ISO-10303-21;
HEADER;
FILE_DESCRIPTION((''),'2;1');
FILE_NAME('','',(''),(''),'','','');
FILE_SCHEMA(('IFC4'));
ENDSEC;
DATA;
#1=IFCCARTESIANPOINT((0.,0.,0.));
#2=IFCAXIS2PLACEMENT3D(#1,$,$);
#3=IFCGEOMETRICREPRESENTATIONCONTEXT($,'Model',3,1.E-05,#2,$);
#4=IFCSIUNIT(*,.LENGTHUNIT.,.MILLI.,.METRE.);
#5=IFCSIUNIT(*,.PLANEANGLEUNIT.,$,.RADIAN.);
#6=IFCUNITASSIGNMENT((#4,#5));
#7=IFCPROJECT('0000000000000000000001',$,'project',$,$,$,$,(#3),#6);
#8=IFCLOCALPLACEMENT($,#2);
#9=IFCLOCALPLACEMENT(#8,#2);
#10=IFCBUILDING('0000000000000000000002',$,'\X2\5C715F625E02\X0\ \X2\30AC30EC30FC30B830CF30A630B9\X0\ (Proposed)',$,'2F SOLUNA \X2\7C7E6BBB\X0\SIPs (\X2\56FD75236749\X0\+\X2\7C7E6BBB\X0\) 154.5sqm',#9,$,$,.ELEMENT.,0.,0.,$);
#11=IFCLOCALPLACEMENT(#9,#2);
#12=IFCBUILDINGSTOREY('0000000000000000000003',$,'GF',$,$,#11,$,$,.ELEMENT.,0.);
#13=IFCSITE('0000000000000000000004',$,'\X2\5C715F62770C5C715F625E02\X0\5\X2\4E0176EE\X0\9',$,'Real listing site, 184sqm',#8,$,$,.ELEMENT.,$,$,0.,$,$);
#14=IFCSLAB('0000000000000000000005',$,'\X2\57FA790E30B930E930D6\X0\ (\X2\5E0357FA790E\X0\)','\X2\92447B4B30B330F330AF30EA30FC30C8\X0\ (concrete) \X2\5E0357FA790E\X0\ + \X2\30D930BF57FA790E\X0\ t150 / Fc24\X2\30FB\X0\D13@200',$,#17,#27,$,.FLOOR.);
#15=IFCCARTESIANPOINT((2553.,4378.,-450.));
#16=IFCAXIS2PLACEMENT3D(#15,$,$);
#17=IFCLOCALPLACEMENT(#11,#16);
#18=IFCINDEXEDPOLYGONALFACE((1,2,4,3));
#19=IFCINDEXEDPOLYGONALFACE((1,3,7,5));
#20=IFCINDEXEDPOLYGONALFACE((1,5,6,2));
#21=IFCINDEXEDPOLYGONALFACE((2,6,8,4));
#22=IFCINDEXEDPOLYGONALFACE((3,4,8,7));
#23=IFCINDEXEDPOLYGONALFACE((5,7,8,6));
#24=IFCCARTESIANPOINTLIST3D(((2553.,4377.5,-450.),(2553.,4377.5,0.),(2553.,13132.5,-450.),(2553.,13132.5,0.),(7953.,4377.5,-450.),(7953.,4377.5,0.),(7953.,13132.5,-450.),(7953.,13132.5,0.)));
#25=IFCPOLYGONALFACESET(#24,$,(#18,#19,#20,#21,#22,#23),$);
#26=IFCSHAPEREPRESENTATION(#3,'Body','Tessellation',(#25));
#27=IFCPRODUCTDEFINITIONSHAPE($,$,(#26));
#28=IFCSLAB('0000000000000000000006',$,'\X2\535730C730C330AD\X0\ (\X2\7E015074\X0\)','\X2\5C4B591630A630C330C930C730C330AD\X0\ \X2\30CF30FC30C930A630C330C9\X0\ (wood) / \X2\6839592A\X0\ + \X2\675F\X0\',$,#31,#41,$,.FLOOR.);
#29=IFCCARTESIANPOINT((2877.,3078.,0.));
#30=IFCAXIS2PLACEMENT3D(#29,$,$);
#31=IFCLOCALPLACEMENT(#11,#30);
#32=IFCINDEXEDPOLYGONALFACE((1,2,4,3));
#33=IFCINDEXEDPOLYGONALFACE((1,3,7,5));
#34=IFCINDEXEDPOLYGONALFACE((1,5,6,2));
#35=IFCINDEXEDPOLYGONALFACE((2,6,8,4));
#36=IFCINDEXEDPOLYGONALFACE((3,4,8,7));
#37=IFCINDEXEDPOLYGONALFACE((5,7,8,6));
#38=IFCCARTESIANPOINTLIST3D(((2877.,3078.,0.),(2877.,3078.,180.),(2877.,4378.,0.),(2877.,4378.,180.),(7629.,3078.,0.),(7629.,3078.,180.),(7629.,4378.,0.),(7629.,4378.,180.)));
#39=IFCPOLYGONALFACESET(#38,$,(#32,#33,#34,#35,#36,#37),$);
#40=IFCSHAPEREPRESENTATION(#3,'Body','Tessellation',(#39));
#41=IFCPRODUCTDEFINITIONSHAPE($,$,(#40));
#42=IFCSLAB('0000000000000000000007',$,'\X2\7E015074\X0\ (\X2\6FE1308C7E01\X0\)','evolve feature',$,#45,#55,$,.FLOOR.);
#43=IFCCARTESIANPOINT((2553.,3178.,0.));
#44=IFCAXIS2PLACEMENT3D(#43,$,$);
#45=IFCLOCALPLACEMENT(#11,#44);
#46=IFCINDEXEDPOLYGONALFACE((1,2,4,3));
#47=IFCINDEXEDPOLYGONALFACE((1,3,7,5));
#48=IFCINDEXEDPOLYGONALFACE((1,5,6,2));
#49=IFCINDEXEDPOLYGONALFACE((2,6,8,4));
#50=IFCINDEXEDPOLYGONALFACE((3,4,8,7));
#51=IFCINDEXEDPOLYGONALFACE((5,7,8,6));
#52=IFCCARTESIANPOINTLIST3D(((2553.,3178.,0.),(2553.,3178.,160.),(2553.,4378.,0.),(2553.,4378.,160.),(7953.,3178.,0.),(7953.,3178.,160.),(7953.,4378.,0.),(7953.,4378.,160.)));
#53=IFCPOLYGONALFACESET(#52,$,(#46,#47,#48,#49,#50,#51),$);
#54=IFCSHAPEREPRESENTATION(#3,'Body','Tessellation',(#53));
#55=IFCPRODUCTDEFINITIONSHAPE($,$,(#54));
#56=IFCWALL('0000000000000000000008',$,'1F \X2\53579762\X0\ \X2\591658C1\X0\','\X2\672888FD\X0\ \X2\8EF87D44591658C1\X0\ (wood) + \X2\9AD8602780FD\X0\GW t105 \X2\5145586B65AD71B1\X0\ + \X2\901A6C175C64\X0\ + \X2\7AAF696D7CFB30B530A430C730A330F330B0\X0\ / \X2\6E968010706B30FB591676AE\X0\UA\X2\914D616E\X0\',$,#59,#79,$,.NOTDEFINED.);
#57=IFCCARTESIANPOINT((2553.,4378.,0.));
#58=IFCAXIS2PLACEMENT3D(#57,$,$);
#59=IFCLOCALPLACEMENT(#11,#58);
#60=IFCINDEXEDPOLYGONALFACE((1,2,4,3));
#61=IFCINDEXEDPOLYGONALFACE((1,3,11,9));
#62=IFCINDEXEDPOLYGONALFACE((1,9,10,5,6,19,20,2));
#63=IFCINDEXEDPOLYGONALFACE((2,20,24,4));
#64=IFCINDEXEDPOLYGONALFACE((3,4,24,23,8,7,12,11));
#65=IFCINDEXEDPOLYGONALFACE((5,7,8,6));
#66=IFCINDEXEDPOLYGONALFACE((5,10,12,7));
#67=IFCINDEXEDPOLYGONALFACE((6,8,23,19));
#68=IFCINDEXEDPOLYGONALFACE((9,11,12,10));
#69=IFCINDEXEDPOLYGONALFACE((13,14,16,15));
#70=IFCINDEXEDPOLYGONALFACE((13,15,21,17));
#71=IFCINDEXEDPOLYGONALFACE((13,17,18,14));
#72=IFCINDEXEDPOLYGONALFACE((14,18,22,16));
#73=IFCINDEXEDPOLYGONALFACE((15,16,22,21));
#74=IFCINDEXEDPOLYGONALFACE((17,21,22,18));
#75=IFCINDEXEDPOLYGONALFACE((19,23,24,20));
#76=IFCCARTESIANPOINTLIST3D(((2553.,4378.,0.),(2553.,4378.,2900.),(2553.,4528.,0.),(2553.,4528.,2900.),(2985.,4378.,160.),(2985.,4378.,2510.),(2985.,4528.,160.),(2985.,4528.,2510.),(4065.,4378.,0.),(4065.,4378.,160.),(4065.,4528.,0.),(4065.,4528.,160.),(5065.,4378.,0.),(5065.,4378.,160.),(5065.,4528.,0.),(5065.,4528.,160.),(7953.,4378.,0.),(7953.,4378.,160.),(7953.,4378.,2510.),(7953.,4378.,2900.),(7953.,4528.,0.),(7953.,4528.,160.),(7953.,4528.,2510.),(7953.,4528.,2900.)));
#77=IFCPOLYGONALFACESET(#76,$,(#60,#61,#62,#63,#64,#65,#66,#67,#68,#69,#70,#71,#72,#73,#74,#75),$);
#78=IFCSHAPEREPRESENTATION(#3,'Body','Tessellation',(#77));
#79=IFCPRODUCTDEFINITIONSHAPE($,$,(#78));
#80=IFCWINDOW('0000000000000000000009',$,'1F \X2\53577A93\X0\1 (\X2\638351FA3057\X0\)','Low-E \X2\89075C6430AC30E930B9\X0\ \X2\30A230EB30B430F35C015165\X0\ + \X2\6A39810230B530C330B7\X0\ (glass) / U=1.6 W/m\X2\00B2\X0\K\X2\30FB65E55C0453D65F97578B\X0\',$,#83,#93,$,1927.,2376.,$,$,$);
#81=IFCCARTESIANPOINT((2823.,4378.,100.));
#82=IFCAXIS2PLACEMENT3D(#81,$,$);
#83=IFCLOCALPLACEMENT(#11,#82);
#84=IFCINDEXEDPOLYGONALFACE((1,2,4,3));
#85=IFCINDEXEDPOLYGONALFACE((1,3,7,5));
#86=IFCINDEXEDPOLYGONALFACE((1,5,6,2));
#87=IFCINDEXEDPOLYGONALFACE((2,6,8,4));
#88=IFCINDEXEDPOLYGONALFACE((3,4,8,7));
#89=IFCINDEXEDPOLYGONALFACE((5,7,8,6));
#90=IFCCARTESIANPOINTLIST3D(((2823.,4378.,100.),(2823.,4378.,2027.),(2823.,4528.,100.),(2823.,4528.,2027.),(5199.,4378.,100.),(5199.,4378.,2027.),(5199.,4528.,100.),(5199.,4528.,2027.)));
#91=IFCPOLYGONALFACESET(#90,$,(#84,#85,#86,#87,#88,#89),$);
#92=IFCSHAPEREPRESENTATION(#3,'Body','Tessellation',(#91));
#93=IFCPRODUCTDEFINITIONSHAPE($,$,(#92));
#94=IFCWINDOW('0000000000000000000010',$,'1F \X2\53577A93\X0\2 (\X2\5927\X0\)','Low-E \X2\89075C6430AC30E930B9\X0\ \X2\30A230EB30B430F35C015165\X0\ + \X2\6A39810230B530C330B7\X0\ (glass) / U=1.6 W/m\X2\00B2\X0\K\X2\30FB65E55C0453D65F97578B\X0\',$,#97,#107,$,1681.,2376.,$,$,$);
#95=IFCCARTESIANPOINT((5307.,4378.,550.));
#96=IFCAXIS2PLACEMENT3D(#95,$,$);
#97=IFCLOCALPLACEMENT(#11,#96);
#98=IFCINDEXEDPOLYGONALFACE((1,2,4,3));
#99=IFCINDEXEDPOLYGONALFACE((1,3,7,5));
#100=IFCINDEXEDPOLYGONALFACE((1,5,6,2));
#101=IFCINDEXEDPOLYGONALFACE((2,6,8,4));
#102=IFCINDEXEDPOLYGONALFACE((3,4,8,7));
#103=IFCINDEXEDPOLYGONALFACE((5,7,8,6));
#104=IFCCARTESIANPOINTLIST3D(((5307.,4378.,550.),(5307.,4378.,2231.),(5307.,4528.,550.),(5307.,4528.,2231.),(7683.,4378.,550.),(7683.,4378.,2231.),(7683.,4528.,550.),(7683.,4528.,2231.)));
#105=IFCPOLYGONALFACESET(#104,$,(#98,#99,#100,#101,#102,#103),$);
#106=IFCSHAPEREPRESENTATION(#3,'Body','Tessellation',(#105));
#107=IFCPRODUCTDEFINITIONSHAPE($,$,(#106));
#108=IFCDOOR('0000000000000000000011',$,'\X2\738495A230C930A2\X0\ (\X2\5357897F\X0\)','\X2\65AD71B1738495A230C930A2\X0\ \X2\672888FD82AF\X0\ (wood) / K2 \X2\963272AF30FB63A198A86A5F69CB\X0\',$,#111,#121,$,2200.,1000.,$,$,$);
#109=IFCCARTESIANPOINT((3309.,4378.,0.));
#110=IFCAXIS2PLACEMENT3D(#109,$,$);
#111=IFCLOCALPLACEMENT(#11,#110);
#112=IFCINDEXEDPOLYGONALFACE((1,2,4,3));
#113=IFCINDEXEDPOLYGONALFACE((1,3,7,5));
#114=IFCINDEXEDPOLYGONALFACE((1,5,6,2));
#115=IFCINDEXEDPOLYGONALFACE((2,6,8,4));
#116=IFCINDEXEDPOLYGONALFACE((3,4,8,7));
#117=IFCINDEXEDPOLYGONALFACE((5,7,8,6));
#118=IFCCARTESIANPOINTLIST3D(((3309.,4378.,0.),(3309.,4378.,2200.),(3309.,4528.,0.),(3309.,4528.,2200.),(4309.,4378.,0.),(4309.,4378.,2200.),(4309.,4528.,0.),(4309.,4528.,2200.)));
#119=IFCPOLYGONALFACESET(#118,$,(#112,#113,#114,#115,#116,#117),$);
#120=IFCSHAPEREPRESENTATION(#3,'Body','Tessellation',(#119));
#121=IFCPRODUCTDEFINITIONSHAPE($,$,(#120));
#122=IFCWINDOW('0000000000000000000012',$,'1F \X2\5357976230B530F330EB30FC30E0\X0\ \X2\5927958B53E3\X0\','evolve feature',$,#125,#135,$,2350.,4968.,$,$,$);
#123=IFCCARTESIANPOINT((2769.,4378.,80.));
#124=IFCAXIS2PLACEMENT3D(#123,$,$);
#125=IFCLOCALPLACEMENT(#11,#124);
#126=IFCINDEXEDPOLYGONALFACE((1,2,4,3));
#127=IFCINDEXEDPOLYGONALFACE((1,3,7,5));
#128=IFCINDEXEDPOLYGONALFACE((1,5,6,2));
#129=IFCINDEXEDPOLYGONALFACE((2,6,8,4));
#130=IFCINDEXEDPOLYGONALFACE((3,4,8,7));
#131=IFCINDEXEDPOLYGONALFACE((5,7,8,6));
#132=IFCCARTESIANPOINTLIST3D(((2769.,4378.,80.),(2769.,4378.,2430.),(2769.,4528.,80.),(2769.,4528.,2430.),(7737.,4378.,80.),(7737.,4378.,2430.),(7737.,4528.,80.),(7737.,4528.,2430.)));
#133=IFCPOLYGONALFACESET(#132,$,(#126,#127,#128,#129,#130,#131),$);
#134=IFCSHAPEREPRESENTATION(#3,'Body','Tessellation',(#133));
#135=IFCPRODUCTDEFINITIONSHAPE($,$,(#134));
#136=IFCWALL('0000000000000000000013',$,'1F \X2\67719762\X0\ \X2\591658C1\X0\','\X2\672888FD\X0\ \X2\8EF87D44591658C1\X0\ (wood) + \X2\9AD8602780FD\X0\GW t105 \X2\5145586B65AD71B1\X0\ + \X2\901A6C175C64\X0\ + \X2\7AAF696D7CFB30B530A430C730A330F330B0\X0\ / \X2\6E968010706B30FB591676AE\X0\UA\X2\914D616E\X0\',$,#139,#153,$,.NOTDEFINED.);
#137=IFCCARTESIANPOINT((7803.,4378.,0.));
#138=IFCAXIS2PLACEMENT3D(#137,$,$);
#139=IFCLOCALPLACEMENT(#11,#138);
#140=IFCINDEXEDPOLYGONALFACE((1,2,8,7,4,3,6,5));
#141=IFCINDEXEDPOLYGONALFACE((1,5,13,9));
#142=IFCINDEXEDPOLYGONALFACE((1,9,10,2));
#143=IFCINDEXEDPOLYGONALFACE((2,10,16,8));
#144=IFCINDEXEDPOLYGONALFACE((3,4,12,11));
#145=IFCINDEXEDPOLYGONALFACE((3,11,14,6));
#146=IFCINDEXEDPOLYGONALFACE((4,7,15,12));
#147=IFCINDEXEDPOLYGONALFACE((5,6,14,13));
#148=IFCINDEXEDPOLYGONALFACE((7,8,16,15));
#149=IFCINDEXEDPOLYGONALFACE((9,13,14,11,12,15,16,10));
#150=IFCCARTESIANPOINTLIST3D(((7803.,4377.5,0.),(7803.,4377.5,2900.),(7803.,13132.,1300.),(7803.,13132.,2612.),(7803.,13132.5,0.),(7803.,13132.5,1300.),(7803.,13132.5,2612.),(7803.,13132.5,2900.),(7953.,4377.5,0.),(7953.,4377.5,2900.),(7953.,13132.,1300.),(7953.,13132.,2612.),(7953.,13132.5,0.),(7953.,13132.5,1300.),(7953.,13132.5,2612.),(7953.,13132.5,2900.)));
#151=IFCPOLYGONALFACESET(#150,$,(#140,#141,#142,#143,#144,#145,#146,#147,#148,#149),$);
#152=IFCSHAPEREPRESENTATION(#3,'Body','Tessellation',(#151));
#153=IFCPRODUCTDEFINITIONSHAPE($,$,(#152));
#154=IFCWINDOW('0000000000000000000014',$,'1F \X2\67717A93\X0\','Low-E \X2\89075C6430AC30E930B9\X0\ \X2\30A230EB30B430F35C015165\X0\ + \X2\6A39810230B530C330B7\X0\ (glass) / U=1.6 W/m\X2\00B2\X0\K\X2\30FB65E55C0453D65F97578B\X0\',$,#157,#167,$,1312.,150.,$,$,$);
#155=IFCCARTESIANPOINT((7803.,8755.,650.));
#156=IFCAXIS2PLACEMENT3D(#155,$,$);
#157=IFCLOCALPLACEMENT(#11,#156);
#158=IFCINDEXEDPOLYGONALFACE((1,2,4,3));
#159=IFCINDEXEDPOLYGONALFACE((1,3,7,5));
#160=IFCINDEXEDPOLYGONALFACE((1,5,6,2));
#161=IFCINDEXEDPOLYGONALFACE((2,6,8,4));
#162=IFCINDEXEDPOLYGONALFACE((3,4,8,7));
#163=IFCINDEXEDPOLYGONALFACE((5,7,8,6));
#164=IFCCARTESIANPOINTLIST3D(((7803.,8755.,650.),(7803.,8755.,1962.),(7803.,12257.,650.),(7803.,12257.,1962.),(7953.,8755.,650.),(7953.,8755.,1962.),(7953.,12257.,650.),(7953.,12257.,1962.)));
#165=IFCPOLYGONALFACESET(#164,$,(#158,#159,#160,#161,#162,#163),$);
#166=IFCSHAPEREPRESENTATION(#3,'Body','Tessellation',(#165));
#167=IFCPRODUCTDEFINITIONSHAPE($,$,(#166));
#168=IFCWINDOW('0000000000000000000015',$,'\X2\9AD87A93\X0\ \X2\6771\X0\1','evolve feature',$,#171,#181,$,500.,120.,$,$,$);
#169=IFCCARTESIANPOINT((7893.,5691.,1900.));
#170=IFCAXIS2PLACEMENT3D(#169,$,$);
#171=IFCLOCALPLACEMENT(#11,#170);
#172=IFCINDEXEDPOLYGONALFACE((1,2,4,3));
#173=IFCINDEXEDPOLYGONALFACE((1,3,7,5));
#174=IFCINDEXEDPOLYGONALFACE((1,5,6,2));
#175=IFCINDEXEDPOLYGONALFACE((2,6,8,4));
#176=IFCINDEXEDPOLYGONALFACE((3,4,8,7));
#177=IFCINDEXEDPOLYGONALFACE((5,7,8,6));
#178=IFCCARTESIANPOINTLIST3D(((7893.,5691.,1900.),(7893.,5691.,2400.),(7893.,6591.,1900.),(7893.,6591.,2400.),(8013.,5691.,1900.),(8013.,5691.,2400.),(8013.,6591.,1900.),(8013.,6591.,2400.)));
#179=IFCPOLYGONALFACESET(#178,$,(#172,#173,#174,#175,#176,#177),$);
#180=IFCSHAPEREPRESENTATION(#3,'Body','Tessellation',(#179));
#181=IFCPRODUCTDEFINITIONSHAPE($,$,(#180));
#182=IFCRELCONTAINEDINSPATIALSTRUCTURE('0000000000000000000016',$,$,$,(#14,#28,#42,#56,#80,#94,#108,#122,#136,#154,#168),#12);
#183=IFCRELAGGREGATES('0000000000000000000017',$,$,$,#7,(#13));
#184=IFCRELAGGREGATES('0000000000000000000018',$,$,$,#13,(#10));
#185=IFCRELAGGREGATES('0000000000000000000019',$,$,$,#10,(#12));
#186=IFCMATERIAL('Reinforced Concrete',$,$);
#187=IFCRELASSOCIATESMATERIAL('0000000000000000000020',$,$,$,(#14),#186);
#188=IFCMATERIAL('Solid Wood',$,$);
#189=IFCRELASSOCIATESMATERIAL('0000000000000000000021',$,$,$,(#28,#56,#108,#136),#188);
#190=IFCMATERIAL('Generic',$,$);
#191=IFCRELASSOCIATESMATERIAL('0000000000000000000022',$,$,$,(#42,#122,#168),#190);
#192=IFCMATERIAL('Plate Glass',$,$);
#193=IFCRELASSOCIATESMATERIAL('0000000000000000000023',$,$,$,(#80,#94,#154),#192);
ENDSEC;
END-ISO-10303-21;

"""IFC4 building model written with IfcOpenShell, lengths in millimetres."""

from ifc_helpers import new_model, si_unit, frame, frame_2d, origin, place, context, project, spatial, rectangle, extrude, material, element, fill, save


model = new_model("IFC4")

# Units and contexts
model_context = context("Model", 3, precision=1e-05, world=origin())
ifc_project = project(units=[si_unit("LENGTHUNIT", "METRE", prefix="MILLI"), si_unit("PLANEANGLEUNIT", "RADIAN")], contexts=[model_context])

# Site, building, storey
site_placement = place(None, origin())
site = spatial("IfcSite", under=ifc_project, at=site_placement, Name="山形県山形市5丁目9", ObjectType="Real listing site, 184sqm", CompositionType="ELEMENT", RefElevation=0.0)
building_placement = place(site_placement, origin())
building = spatial("IfcBuilding", under=site, at=building_placement, Name="山形市 ガレージハウス (Proposed)", ObjectType="2F SOLUNA 籾殻SIPs (国産杉+籾殻) 154.5sqm", CompositionType="ELEMENT", ElevationOfRefHeight=0.0, ElevationOfTerrain=0.0)
storey_placement = place(building_placement, origin())
storey = spatial("IfcBuildingStorey", under=building, at=storey_placement, Name="GF", CompositionType="ELEMENT", Elevation=0.0)

# Slabs
ifc_material_1 = material(Name="Reinforced Concrete")
slab_1_placement = place(storey_placement, frame((2553.0, 4378.0, -450.0)))
element("IfcSlab", 1, at=slab_1_placement, inside=storey, material=ifc_material_1, Name="基礎スラブ (布基礎)", Description="鉄筋コンクリート (concrete) 布基礎 + ベタ基礎 t150 / Fc24・D13@200", PredefinedType="FLOOR", context=model_context, shape_type="SweptSolid", body=[
    extrude(rectangle(XDim=5400.0, YDim=8755.0, at=frame_2d((2700.0, 4377.0))), frame((2553.0, 4378.0, -450.0)), (0.0, 0.0, 1.0), 450.0),
])
ifc_material_2 = material(Name="Solid Wood")
slab_2_placement = place(storey_placement, frame((2877.0, 3078.0, 0.0)))
element("IfcSlab", 2, at=slab_2_placement, inside=storey, material=ifc_material_2, Name="南デッキ (縁側)", Description="屋外ウッドデッキ ハードウッド (wood) / 根太 + 束", PredefinedType="FLOOR", context=model_context, shape_type="SweptSolid", body=[
    extrude(rectangle(XDim=4752.0, YDim=1300.0, at=frame_2d((2376.0, 650.0))), frame((2877.0, 3078.0, 0.0)), (0.0, 0.0, 1.0), 180.0),
])
ifc_material_3 = material(Name="Generic")
slab_3_placement = place(storey_placement, frame((2553.0, 3178.0, 0.0)))
element("IfcSlab", 3, at=slab_3_placement, inside=storey, material=ifc_material_3, Name="縁側 (濡れ縁)", Description="evolve feature", PredefinedType="FLOOR", context=model_context, shape_type="SweptSolid", body=[
    extrude(rectangle(XDim=5400.0, YDim=1200.0, at=frame_2d((2700.0, 600.0))), frame((2553.0, 3178.0, 0.0)), (0.0, 0.0, 1.0), 160.0),
])

# Wall, openings, windows, door
wall_1_placement = place(storey_placement, frame((2553.0, 4378.0, 0.0)))
wall_1 = element("IfcWall", 4, at=wall_1_placement, inside=storey, material=ifc_material_2, Name="1F 南面 外壁", Description="木製 軸組外壁 (wood) + 高性能GW t105 充填断熱 + 通気層 + 窯業系サイディング / 準耐火・外皮UA配慮", PredefinedType="NOTDEFINED", context=model_context, shape_type="SweptSolid", body=[
    extrude(rectangle(XDim=5400.0, YDim=150.0, at=frame_2d((2700.0, 75.0))), frame((2553.0, 4378.0, 0.0)), (0.0, 0.0, 1.0), 2900.0),
])
opening_1_placement = place(storey_placement, frame((2823.0, 4378.0, 100.0)))
opening_1 = element("IfcOpeningElement", 5, at=opening_1_placement, cuts=wall_1, PredefinedType="NOTDEFINED", context=model_context, shape_type="SweptSolid", body=[
    extrude(rectangle(XDim=2376.0, YDim=150.0, at=frame_2d((1188.0, 75.0))), frame((2823.0, 4378.0, 100.0)), (0.0, 0.0, 1.0), 1927.0),
])
opening_2_placement = place(storey_placement, frame((5307.0, 4378.0, 550.0)))
opening_2 = element("IfcOpeningElement", 6, at=opening_2_placement, cuts=wall_1, PredefinedType="NOTDEFINED", context=model_context, shape_type="SweptSolid", body=[
    extrude(rectangle(XDim=2376.0, YDim=150.0, at=frame_2d((1188.0, 75.0))), frame((5307.0, 4378.0, 550.0)), (0.0, 0.0, 1.0), 1681.0),
])
opening_3_placement = place(storey_placement, frame((3309.0, 4378.0, 0.0)))
opening_3 = element("IfcOpeningElement", 7, at=opening_3_placement, cuts=wall_1, PredefinedType="NOTDEFINED", context=model_context, shape_type="SweptSolid", body=[
    extrude(rectangle(XDim=1000.0, YDim=150.0, at=frame_2d((500.0, 75.0))), frame((3309.0, 4378.0, 0.0)), (0.0, 0.0, 1.0), 2200.0),
])
opening_4_placement = place(storey_placement, frame((2769.0, 4378.0, 80.0)))
opening_4 = element("IfcOpeningElement", 8, at=opening_4_placement, cuts=wall_1, PredefinedType="NOTDEFINED", context=model_context, shape_type="SweptSolid", body=[
    extrude(rectangle(XDim=4968.0, YDim=150.0, at=frame_2d((2484.0, 75.0))), frame((2769.0, 4378.0, 80.0)), (0.0, 0.0, 1.0), 2350.0),
])
ifc_material_4 = material(Name="Plate Glass")
window_1_placement = place(storey_placement, frame((2823.0, 4378.0, 100.0)))
window_1 = element("IfcWindow", 9, at=window_1_placement, inside=storey, material=ifc_material_4, Name="1F 南窓1 (掃出し)", Description="Low-E 複層ガラス アルゴン封入 + 樹脂サッシ (glass) / U=1.6 W/m²K・日射取得型", OverallHeight=1927.0, OverallWidth=2376.0, context=model_context, shape_type="SweptSolid", body=[
    extrude(rectangle(XDim=2376.0, YDim=150.0, at=frame_2d((1188.0, 75.0))), frame((2823.0, 4378.0, 100.0)), (0.0, 0.0, 1.0), 1927.0),
])
fill(opening_1, window_1)
window_2_placement = place(storey_placement, frame((5307.0, 4378.0, 550.0)))
window_2 = element("IfcWindow", 10, at=window_2_placement, inside=storey, material=ifc_material_4, Name="1F 南窓2 (大)", Description="Low-E 複層ガラス アルゴン封入 + 樹脂サッシ (glass) / U=1.6 W/m²K・日射取得型", OverallHeight=1681.0, OverallWidth=2376.0, context=model_context, shape_type="SweptSolid", body=[
    extrude(rectangle(XDim=2376.0, YDim=150.0, at=frame_2d((1188.0, 75.0))), frame((5307.0, 4378.0, 550.0)), (0.0, 0.0, 1.0), 1681.0),
])
fill(opening_2, window_2)
door_placement = place(storey_placement, frame((3309.0, 4378.0, 0.0)))
door = element("IfcDoor", 11, at=door_placement, inside=storey, material=ifc_material_2, Name="玄関ドア (南西)", Description="断熱玄関ドア 木製芯 (wood) / K2 防犯・採風機構", OverallHeight=2200.0, OverallWidth=1000.0, context=model_context, shape_type="SweptSolid", body=[
    extrude(rectangle(XDim=1000.0, YDim=150.0, at=frame_2d((500.0, 75.0))), frame((3309.0, 4378.0, 0.0)), (0.0, 0.0, 1.0), 2200.0),
])
fill(opening_3, door)
window_3_placement = place(storey_placement, frame((2769.0, 4378.0, 80.0)))
window_3 = element("IfcWindow", 12, at=window_3_placement, inside=storey, material=ifc_material_3, Name="1F 南面サンルーム 大開口", Description="evolve feature", OverallHeight=2350.0, OverallWidth=4968.0, context=model_context, shape_type="SweptSolid", body=[
    extrude(rectangle(XDim=4968.0, YDim=150.0, at=frame_2d((2484.0, 75.0))), frame((2769.0, 4378.0, 80.0)), (0.0, 0.0, 1.0), 2350.0),
])
fill(opening_4, window_3)

# Wall, openings, windows
wall_2_placement = place(storey_placement, frame((7803.0, 4378.0, 0.0)))
wall_2 = element("IfcWall", 13, at=wall_2_placement, inside=storey, material=ifc_material_2, Name="1F 東面 外壁", Description="木製 軸組外壁 (wood) + 高性能GW t105 充填断熱 + 通気層 + 窯業系サイディング / 準耐火・外皮UA配慮", PredefinedType="NOTDEFINED", context=model_context, shape_type="SweptSolid", body=[
    extrude(rectangle(XDim=150.0, YDim=8755.0, at=frame_2d((75.0, 4377.0))), frame((7803.0, 4378.0, 0.0)), (0.0, 0.0, 1.0), 2900.0),
])
opening_5_placement = place(storey_placement, frame((7803.0, 8755.0, 650.0)))
opening_5 = element("IfcOpeningElement", 14, at=opening_5_placement, cuts=wall_2, PredefinedType="NOTDEFINED", context=model_context, shape_type="SweptSolid", body=[
    extrude(rectangle(XDim=150.0, YDim=3502.0, at=frame_2d((75.0, 1751.0))), frame((7803.0, 8755.0, 650.0)), (0.0, 0.0, 1.0), 1312.0),
])
opening_6_placement = place(storey_placement, frame((7893.0, 5691.0, 1900.0)))
opening_6 = element("IfcOpeningElement", 15, at=opening_6_placement, cuts=wall_2, PredefinedType="NOTDEFINED", context=model_context, shape_type="SweptSolid", body=[
    extrude(rectangle(XDim=120.0, YDim=900.0, at=frame_2d((60.0, 450.0))), frame((7893.0, 5691.0, 1900.0)), (0.0, 0.0, 1.0), 500.0),
])
window_4_placement = place(storey_placement, frame((7803.0, 8755.0, 650.0)))
window_4 = element("IfcWindow", 16, at=window_4_placement, inside=storey, material=ifc_material_4, Name="1F 東窓", Description="Low-E 複層ガラス アルゴン封入 + 樹脂サッシ (glass) / U=1.6 W/m²K・日射取得型", OverallHeight=1312.0, OverallWidth=150.0, context=model_context, shape_type="SweptSolid", body=[
    extrude(rectangle(XDim=150.0, YDim=3502.0, at=frame_2d((75.0, 1751.0))), frame((7803.0, 8755.0, 650.0)), (0.0, 0.0, 1.0), 1312.0),
])
fill(opening_5, window_4)
window_5_placement = place(storey_placement, frame((7893.0, 5691.0, 1900.0)))
window_5 = element("IfcWindow", 17, at=window_5_placement, inside=storey, material=ifc_material_3, Name="高窓 東1", Description="evolve feature", OverallHeight=500.0, OverallWidth=120.0, context=model_context, shape_type="SweptSolid", body=[
    extrude(rectangle(XDim=120.0, YDim=900.0, at=frame_2d((60.0, 450.0))), frame((7893.0, 5691.0, 1900.0)), (0.0, 0.0, 1.0), 500.0),
])
fill(opening_6, window_5)

save(model, "model.ifc")
